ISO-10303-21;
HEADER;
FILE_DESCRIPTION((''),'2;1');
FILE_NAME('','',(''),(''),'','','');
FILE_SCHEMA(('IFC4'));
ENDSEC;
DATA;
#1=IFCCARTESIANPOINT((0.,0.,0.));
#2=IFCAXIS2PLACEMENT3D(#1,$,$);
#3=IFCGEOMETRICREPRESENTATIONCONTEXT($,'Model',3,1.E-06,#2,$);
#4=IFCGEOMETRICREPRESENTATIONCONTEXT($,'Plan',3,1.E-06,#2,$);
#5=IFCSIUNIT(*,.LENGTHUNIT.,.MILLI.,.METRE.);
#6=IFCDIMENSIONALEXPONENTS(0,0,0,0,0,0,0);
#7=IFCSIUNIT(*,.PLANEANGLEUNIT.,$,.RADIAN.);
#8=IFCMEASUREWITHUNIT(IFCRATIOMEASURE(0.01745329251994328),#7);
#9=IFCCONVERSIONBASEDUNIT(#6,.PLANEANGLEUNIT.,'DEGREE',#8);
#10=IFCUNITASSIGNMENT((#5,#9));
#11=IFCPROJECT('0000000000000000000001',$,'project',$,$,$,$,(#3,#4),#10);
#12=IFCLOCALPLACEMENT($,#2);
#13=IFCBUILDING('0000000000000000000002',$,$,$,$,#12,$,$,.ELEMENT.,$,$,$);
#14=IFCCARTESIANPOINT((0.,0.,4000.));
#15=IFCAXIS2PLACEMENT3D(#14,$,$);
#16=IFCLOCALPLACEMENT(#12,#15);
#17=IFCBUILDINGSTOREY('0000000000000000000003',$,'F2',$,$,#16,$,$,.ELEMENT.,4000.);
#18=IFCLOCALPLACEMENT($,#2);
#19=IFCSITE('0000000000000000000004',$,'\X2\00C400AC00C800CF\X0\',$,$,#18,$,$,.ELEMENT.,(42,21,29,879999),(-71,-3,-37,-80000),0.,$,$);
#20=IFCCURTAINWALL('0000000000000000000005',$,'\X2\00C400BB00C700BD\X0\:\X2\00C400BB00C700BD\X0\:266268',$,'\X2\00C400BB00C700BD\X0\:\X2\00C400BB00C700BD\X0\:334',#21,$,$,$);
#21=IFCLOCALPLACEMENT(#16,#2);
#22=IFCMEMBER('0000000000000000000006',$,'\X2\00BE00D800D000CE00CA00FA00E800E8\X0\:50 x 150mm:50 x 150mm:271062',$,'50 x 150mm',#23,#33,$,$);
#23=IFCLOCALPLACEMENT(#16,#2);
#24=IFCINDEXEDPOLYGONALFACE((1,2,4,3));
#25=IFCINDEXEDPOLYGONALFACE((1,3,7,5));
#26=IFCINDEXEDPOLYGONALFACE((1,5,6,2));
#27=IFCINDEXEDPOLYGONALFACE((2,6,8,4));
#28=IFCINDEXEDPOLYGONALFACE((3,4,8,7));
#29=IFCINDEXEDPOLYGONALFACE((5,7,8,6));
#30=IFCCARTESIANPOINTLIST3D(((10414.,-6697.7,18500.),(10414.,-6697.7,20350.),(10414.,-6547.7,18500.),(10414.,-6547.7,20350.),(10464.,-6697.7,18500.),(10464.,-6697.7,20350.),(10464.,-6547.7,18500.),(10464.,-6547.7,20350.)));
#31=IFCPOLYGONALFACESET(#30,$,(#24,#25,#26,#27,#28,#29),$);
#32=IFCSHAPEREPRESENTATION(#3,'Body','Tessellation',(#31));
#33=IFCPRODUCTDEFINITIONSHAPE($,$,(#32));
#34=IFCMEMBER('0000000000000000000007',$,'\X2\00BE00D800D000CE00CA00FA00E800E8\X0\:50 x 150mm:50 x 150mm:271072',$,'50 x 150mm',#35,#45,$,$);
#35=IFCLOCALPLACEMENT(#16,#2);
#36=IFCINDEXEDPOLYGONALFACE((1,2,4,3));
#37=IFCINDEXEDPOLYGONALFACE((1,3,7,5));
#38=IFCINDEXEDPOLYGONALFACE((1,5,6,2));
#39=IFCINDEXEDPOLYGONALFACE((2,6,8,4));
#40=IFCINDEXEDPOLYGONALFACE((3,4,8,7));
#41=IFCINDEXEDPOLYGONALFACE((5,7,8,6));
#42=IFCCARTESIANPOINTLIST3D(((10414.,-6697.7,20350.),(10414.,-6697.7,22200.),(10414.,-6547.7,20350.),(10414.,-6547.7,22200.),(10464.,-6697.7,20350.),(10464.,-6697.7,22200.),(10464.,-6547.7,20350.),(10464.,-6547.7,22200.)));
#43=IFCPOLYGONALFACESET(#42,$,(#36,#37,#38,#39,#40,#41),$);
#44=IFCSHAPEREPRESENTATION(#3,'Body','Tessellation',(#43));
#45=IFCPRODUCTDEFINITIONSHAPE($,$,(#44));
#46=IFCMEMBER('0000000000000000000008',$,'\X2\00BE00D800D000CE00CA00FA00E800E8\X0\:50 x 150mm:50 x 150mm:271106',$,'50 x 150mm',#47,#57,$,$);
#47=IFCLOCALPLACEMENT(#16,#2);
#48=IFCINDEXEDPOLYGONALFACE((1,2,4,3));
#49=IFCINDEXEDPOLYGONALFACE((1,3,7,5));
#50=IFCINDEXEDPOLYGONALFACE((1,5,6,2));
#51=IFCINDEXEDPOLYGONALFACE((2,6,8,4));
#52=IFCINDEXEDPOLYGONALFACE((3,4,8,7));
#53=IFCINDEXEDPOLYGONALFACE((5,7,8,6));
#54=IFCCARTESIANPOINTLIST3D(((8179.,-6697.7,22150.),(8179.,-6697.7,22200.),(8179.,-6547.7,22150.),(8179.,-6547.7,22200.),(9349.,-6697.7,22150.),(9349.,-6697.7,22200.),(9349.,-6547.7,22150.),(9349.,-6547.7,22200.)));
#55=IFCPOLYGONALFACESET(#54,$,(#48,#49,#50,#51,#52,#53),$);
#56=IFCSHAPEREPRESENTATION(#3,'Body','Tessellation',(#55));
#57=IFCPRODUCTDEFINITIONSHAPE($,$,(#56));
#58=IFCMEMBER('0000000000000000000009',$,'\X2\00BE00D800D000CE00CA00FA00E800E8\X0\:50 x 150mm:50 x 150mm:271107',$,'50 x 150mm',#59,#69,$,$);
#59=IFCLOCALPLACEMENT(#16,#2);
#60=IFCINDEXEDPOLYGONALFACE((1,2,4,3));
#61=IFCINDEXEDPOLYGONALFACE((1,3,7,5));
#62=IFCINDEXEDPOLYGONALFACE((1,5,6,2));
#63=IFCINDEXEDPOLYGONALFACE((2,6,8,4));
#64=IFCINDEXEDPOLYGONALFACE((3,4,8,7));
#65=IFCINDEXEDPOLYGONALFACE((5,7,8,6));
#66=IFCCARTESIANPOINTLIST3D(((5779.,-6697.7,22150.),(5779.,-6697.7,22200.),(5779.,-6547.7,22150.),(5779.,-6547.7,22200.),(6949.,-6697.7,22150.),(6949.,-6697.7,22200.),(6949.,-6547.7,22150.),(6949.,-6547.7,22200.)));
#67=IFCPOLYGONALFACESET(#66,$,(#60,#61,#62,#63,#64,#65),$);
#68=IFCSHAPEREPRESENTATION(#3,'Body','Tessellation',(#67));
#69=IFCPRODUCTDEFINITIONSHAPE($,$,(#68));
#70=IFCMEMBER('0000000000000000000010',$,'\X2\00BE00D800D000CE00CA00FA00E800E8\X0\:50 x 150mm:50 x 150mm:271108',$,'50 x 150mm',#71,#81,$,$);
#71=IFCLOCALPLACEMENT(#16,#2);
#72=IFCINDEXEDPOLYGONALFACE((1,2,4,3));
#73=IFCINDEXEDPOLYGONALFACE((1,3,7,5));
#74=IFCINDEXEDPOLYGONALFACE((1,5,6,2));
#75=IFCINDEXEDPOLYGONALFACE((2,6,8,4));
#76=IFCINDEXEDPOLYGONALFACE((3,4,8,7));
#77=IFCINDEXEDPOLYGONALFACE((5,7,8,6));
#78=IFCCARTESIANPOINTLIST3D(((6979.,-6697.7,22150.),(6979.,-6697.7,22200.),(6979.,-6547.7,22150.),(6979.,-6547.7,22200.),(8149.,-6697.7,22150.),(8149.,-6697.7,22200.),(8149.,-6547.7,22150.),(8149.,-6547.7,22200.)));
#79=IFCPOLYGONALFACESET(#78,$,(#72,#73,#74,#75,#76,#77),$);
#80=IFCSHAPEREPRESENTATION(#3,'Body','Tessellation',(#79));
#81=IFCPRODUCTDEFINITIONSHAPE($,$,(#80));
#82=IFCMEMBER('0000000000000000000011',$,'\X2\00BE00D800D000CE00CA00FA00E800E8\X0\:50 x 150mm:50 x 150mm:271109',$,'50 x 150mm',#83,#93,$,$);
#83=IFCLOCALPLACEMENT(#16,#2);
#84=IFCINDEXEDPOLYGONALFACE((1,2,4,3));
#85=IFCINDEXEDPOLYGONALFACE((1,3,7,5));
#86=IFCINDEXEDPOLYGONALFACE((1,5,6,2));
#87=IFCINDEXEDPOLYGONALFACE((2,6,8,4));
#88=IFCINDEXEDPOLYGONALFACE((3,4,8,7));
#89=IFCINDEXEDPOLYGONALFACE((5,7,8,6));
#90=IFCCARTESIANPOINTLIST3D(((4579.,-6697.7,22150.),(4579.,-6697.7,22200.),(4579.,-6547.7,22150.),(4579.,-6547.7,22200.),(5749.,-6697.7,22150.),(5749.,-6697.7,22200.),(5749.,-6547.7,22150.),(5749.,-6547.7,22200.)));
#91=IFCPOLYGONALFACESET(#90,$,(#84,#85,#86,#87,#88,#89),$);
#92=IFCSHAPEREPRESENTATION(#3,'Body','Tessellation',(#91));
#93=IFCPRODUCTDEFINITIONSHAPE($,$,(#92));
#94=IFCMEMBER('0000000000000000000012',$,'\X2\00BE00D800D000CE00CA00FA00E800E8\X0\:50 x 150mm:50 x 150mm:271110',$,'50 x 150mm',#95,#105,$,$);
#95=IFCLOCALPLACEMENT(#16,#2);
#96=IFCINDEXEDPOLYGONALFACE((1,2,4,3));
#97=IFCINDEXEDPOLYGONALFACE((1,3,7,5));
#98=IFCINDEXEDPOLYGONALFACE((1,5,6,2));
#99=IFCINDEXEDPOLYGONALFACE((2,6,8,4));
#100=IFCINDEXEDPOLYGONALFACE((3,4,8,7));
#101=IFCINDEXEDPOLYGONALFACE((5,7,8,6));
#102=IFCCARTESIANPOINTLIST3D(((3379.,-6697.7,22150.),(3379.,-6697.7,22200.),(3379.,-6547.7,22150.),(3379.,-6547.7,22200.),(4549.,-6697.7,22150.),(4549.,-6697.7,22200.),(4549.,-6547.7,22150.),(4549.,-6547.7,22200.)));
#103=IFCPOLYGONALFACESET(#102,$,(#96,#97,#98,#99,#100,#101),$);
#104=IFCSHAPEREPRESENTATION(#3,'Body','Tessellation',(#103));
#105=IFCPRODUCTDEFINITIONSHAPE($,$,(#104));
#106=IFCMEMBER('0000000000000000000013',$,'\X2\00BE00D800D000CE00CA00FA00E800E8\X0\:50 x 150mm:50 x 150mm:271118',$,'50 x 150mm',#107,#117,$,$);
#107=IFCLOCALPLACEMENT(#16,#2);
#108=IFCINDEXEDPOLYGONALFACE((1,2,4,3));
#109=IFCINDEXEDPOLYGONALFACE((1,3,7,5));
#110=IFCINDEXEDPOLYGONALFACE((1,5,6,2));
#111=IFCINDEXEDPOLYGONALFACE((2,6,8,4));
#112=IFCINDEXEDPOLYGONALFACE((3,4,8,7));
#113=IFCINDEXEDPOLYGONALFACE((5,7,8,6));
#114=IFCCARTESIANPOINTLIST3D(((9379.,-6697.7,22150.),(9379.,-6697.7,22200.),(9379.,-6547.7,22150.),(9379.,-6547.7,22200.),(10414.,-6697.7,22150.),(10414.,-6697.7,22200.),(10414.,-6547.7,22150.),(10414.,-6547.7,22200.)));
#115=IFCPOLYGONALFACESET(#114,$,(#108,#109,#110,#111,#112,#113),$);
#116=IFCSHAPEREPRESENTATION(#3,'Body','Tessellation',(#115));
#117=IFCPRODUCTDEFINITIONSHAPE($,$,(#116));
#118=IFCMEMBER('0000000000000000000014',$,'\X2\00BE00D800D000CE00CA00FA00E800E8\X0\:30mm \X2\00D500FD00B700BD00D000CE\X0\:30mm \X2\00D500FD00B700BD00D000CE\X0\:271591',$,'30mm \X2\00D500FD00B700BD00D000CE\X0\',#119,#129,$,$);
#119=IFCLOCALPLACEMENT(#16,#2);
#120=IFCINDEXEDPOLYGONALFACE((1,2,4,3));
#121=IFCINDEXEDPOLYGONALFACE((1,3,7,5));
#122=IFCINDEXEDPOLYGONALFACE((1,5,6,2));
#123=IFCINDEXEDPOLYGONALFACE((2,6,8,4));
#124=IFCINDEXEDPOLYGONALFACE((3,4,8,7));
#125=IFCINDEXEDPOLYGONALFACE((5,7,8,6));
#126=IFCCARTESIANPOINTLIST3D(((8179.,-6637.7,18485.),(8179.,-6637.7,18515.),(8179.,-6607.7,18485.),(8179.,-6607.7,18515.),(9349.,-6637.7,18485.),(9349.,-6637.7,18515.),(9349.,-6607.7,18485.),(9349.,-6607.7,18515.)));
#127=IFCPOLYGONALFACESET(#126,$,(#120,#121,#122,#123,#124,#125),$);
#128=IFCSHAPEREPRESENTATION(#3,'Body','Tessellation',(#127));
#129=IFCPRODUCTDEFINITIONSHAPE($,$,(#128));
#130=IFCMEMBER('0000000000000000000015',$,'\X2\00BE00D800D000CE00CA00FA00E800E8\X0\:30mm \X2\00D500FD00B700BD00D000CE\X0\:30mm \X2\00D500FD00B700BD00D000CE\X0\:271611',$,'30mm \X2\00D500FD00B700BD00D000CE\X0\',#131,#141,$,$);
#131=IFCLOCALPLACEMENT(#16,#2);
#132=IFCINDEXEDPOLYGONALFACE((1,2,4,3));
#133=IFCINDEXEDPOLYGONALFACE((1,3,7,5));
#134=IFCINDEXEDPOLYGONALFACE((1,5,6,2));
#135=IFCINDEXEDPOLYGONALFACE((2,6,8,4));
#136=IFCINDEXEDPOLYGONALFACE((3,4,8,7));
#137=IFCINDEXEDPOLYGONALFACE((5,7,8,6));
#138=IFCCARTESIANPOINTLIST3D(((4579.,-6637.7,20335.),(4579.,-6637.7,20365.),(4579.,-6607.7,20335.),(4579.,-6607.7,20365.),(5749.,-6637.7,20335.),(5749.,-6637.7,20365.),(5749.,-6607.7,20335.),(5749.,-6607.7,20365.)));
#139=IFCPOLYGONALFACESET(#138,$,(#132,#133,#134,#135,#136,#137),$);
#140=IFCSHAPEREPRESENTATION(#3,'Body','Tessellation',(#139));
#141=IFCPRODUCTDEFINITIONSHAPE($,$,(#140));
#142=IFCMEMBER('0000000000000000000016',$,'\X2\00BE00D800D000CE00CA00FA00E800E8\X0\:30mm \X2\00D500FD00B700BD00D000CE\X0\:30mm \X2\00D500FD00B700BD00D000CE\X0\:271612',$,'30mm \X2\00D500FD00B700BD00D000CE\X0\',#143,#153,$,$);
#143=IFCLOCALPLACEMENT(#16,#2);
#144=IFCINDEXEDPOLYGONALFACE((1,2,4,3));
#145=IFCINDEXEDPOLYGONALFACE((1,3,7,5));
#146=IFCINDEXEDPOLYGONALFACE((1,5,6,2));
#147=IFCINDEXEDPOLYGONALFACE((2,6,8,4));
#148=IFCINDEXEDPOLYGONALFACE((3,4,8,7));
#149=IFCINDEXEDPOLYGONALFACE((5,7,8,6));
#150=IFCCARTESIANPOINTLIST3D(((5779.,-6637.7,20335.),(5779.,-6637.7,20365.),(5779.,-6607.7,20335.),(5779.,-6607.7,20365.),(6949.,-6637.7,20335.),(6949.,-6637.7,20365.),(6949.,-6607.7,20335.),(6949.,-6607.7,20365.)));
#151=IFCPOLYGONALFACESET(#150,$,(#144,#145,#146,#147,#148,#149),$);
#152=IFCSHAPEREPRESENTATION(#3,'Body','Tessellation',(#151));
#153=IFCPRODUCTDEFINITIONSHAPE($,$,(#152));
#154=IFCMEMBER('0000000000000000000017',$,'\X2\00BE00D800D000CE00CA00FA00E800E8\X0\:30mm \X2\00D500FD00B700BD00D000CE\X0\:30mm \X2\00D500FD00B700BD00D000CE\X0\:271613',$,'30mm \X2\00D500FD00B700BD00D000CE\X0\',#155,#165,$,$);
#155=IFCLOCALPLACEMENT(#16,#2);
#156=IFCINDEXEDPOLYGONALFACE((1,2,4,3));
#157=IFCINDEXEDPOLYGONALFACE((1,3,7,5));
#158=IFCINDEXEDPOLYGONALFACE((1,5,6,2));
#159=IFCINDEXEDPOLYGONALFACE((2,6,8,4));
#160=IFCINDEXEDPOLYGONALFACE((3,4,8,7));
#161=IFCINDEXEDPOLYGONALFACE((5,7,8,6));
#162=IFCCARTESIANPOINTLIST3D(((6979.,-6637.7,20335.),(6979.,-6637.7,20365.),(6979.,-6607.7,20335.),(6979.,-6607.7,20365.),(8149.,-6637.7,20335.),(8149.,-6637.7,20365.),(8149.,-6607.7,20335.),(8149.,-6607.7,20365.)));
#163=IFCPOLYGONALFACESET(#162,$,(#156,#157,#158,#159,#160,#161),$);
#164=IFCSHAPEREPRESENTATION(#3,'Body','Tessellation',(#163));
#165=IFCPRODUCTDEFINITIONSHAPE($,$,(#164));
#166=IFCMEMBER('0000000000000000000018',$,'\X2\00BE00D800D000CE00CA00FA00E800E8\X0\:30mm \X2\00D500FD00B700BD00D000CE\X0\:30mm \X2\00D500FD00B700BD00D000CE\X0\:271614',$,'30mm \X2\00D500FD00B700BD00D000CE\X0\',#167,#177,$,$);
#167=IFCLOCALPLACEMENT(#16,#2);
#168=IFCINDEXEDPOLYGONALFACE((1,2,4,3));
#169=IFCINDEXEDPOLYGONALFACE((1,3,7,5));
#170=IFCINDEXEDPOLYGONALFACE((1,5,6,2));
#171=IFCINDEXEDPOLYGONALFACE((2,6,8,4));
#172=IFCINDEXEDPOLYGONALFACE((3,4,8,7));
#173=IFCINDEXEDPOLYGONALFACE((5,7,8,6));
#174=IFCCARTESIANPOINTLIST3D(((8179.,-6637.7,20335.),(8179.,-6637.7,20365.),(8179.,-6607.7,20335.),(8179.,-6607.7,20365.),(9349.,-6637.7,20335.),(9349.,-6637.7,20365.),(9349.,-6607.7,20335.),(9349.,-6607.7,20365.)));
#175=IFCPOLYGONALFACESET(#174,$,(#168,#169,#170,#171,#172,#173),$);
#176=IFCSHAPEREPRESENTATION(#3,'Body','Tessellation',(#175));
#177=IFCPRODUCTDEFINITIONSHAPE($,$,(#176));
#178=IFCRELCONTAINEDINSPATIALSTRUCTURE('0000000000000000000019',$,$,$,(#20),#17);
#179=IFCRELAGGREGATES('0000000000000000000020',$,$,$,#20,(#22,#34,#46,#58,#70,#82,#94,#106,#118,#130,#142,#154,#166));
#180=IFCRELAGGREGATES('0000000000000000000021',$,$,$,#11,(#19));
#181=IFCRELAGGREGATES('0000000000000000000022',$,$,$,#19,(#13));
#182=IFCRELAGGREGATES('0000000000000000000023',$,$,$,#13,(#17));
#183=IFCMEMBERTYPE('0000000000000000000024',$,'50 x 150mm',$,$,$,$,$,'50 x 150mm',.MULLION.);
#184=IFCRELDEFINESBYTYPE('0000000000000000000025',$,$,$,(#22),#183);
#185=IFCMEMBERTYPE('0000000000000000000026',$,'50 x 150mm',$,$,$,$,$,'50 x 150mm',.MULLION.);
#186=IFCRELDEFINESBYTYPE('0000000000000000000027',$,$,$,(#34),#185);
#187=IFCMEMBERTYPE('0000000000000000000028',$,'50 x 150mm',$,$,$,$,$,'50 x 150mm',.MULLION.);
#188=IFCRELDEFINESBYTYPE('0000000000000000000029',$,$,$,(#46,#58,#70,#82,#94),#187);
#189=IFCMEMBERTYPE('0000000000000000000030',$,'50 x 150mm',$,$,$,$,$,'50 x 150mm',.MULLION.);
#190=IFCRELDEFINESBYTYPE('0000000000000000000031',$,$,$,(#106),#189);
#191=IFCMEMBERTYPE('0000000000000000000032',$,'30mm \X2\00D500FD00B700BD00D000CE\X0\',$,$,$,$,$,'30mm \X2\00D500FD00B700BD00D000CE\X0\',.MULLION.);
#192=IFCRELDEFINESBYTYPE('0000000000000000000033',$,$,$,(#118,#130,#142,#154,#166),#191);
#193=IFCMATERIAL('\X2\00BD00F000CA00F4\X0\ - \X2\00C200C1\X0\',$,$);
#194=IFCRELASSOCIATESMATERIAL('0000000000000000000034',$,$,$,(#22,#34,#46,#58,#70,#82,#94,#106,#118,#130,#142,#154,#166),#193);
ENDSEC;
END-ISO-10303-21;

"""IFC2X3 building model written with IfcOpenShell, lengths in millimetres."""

from ifc_helpers import new_model, entity, si_unit, converted_unit, frame, origin, origin_2d_with_axis, place, context, project, spatial, rectangle, extrude, source, transform, mapped, material, type_object, type_shapes, element, aggregate, save


model = new_model("IFC2X3")

# Units and contexts
model_context = context("Model", 3, precision=1e-06, world=origin())
plan_context = context("Plan", 3, precision=1e-06, world=origin())
ifc_project = project(units=[si_unit("LENGTHUNIT", "METRE", prefix="MILLI"), converted_unit("PLANEANGLEUNIT", "DEGREE", entity("IfcRatioMeasure", 0.01745329251994328), si_unit("PLANEANGLEUNIT", "RADIAN"), dimensions=[0, 0, 0, 0, 0, 0, 0])], contexts=[model_context, plan_context])

# Site, building, storey
site_placement = place(None, origin())
site = spatial("IfcSite", under=ifc_project, at=site_placement, Name="Ä¬ÈÏ", CompositionType="ELEMENT", RefLatitude=(42, 21, 29, 879999), RefLongitude=(-71, -3, -37, -80000), RefElevation=0.0)
building_placement = place(None, origin())
building = spatial("IfcBuilding", under=site, at=building_placement, CompositionType="ELEMENT")
storey_placement = place(building_placement, frame((0.0, 0.0, 4000.0)))
storey = spatial("IfcBuildingStorey", under=building, at=storey_placement, Name="F2", CompositionType="ELEMENT", Elevation=4000.0)

# Curtain wall, members
curtain_wall_placement = place(storey_placement, origin())
curtain_wall = element("IfcCurtainWall", 1, at=curtain_wall_placement, inside=storey, Name="Ä»Ç½:Ä»Ç½:266268", ObjectType="Ä»Ç½:Ä»Ç½:334")
ifc_material_1 = material(Name="½ðÊô - ÂÁ")
member_type_1 = type_object("IfcMemberType", Name="50 x 150mm", ElementType="50 x 150mm", PredefinedType="MULLION")
shared_shape_1 = source(origin(), model_context, "Body", "SweptSolid", [
    extrude(rectangle(XDim=50.0, YDim=150.0, at=origin_2d_with_axis()), frame((-25.0, 0.0, -1850.0), z_axis=(0.0, 0.0, 1.0), x_axis=(-1.0, 0.0, 0.0)), (0.0, 0.0, 1.0), 1850.0),
])
type_shapes(member_type_1, [shared_shape_1])
placement_1 = place(building_placement, frame((0.0, 0.0, 22500.0)))
member_1_placement = place(placement_1, frame((10464.0, -6622.7, 0.0), z_axis=(0.0, 0.0, -1.0), x_axis=(1.0, 0.0, 0.0)))
member_1 = element("IfcMember", 2, at=member_1_placement, type_object=member_type_1, material=ifc_material_1, Name="¾ØÐÎÊúèè:50 x 150mm:50 x 150mm:271062", ObjectType="50 x 150mm", context=model_context, shape_type="MappedRepresentation", body=[
    mapped(shared_shape_1, transform((0.0, 0.0, 0.0), scale=1.0)),
])
member_type_2 = type_object("IfcMemberType", Name="50 x 150mm", ElementType="50 x 150mm", PredefinedType="MULLION")
shared_shape_2 = source(origin(), model_context, "Body", "SweptSolid", [
    extrude(rectangle(XDim=50.0, YDim=150.0, at=origin_2d_with_axis()), frame((-25.0, 0.0, -1850.0), z_axis=(0.0, 0.0, 1.0), x_axis=(-1.0, 0.0, 0.0)), (0.0, 0.0, 1.0), 1850.0),
])
type_shapes(member_type_2, [shared_shape_2])
member_2_placement = place(placement_1, frame((10464.0, -6622.7, 1850.0), z_axis=(0.0, 0.0, -1.0), x_axis=(1.0, 0.0, 0.0)))
member_2 = element("IfcMember", 3, at=member_2_placement, type_object=member_type_2, material=ifc_material_1, Name="¾ØÐÎÊúèè:50 x 150mm:50 x 150mm:271072", ObjectType="50 x 150mm", context=model_context, shape_type="MappedRepresentation", body=[
    mapped(shared_shape_2, transform((0.0, 0.0, 0.0), scale=1.0)),
])
member_type_3 = type_object("IfcMemberType", Name="50 x 150mm", ElementType="50 x 150mm", PredefinedType="MULLION")
shared_shape_3 = source(origin(), model_context, "Body", "SweptSolid", [
    extrude(rectangle(XDim=50.0, YDim=150.0, at=origin_2d_with_axis()), frame((-25.0, 0.0, -1170.0), z_axis=(0.0, 0.0, 1.0), x_axis=(-1.0, 0.0, 0.0)), (0.0, 0.0, 1.0), 1170.0),
])
type_shapes(member_type_3, [shared_shape_3])
placement_2 = place(building_placement, frame((0.0, 0.0, 26200.0)))
member_3_placement = place(placement_2, frame((9349.0, -6622.7, 0.0), z_axis=(1.0, 0.0, 0.0), x_axis=(0.0, 0.0, 1.0)))
member_3 = element("IfcMember", 4, at=member_3_placement, type_object=member_type_3, material=ifc_material_1, Name="¾ØÐÎÊúèè:50 x 150mm:50 x 150mm:271106", ObjectType="50 x 150mm", context=model_context, shape_type="MappedRepresentation", body=[
    mapped(shared_shape_3, transform((0.0, 0.0, 0.0), scale=1.0)),
])
member_4_placement = place(placement_2, frame((6949.0, -6622.7, 0.0), z_axis=(1.0, 0.0, 0.0), x_axis=(0.0, 0.0, 1.0)))
member_4 = element("IfcMember", 5, at=member_4_placement, type_object=member_type_3, material=ifc_material_1, Name="¾ØÐÎÊúèè:50 x 150mm:50 x 150mm:271107", ObjectType="50 x 150mm", context=model_context, shape_type="MappedRepresentation", body=[
    mapped(shared_shape_3, transform((0.0, 0.0, 0.0), scale=1.0)),
])
member_5_placement = place(placement_2, frame((8149.0, -6622.7, 0.0), z_axis=(1.0, 0.0, 0.0), x_axis=(0.0, 0.0, 1.0)))
member_5 = element("IfcMember", 6, at=member_5_placement, type_object=member_type_3, material=ifc_material_1, Name="¾ØÐÎÊúèè:50 x 150mm:50 x 150mm:271108", ObjectType="50 x 150mm", context=model_context, shape_type="MappedRepresentation", body=[
    mapped(shared_shape_3, transform((0.0, 0.0, 0.0), scale=1.0)),
])
member_6_placement = place(placement_2, frame((5749.0, -6622.7, 0.0), z_axis=(1.0, 0.0, 0.0), x_axis=(0.0, 0.0, 1.0)))
member_6 = element("IfcMember", 7, at=member_6_placement, type_object=member_type_3, material=ifc_material_1, Name="¾ØÐÎÊúèè:50 x 150mm:50 x 150mm:271109", ObjectType="50 x 150mm", context=model_context, shape_type="MappedRepresentation", body=[
    mapped(shared_shape_3, transform((0.0, 0.0, 0.0), scale=1.0)),
])
member_7_placement = place(placement_2, frame((4549.0, -6622.7, 0.0), z_axis=(1.0, 0.0, 0.0), x_axis=(0.0, 0.0, 1.0)))
member_7 = element("IfcMember", 8, at=member_7_placement, type_object=member_type_3, material=ifc_material_1, Name="¾ØÐÎÊúèè:50 x 150mm:50 x 150mm:271110", ObjectType="50 x 150mm", context=model_context, shape_type="MappedRepresentation", body=[
    mapped(shared_shape_3, transform((0.0, 0.0, 0.0), scale=1.0)),
])
member_type_4 = type_object("IfcMemberType", Name="50 x 150mm", ElementType="50 x 150mm", PredefinedType="MULLION")
shared_shape_4 = source(origin(), model_context, "Body", "SweptSolid", [
    extrude(rectangle(XDim=50.0, YDim=150.0, at=origin_2d_with_axis()), frame((-25.0, 0.0, -1035.0), z_axis=(0.0, 0.0, 1.0), x_axis=(-1.0, 0.0, 0.0)), (0.0, 0.0, 1.0), 1035.0),
])
type_shapes(member_type_4, [shared_shape_4])
member_8_placement = place(placement_2, frame((10414.0, -6622.7, 0.0), z_axis=(1.0, 0.0, 0.0), x_axis=(0.0, 0.0, 1.0)))
member_8 = element("IfcMember", 9, at=member_8_placement, type_object=member_type_4, material=ifc_material_1, Name="¾ØÐÎÊúèè:50 x 150mm:50 x 150mm:271118", ObjectType="50 x 150mm", context=model_context, shape_type="MappedRepresentation", body=[
    mapped(shared_shape_4, transform((0.0, 0.0, 0.0), scale=1.0)),
])
member_type_5 = type_object("IfcMemberType", Name="30mm Õý·½ÐÎ", ElementType="30mm Õý·½ÐÎ", PredefinedType="MULLION")
shared_shape_5 = source(origin(), model_context, "Body", "SweptSolid", [
    extrude(rectangle(XDim=30.0, YDim=30.0, at=origin_2d_with_axis()), frame((0.0, 0.0, -1170.0), z_axis=(0.0, 0.0, 1.0), x_axis=(-1.0, 0.0, 0.0)), (0.0, 0.0, 1.0), 1170.0),
])
type_shapes(member_type_5, [shared_shape_5])
member_9_placement = place(placement_1, frame((9349.0, -6622.7, 0.0), z_axis=(1.0, 0.0, 0.0), x_axis=(0.0, 0.0, 1.0)))
member_9 = element("IfcMember", 10, at=member_9_placement, type_object=member_type_5, material=ifc_material_1, Name="¾ØÐÎÊúèè:30mm Õý·½ÐÎ:30mm Õý·½ÐÎ:271591", ObjectType="30mm Õý·½ÐÎ", context=model_context, shape_type="MappedRepresentation", body=[
    mapped(shared_shape_5, transform((0.0, 0.0, 0.0), scale=1.0)),
])
member_10_placement = place(placement_1, frame((5749.0, -6622.7, 1850.0), z_axis=(1.0, 0.0, 0.0), x_axis=(0.0, 0.0, 1.0)))
member_10 = element("IfcMember", 11, at=member_10_placement, type_object=member_type_5, material=ifc_material_1, Name="¾ØÐÎÊúèè:30mm Õý·½ÐÎ:30mm Õý·½ÐÎ:271611", ObjectType="30mm Õý·½ÐÎ", context=model_context, shape_type="MappedRepresentation", body=[
    mapped(shared_shape_5, transform((0.0, 0.0, 0.0), scale=1.0)),
])
member_11_placement = place(placement_1, frame((6949.0, -6622.7, 1850.0), z_axis=(1.0, 0.0, 0.0), x_axis=(0.0, 0.0, 1.0)))
member_11 = element("IfcMember", 12, at=member_11_placement, type_object=member_type_5, material=ifc_material_1, Name="¾ØÐÎÊúèè:30mm Õý·½ÐÎ:30mm Õý·½ÐÎ:271612", ObjectType="30mm Õý·½ÐÎ", context=model_context, shape_type="MappedRepresentation", body=[
    mapped(shared_shape_5, transform((0.0, 0.0, 0.0), scale=1.0)),
])
member_12_placement = place(placement_1, frame((8149.0, -6622.7, 1850.0), z_axis=(1.0, 0.0, 0.0), x_axis=(0.0, 0.0, 1.0)))
member_12 = element("IfcMember", 13, at=member_12_placement, type_object=member_type_5, material=ifc_material_1, Name="¾ØÐÎÊúèè:30mm Õý·½ÐÎ:30mm Õý·½ÐÎ:271613", ObjectType="30mm Õý·½ÐÎ", context=model_context, shape_type="MappedRepresentation", body=[
    mapped(shared_shape_5, transform((0.0, 0.0, 0.0), scale=1.0)),
])
member_13_placement = place(placement_1, frame((9349.0, -6622.7, 1850.0), z_axis=(1.0, 0.0, 0.0), x_axis=(0.0, 0.0, 1.0)))
member_13 = element("IfcMember", 14, at=member_13_placement, type_object=member_type_5, material=ifc_material_1, Name="¾ØÐÎÊúèè:30mm Õý·½ÐÎ:30mm Õý·½ÐÎ:271614", ObjectType="30mm Õý·½ÐÎ", context=model_context, shape_type="MappedRepresentation", body=[
    mapped(shared_shape_5, transform((0.0, 0.0, 0.0), scale=1.0)),
])
aggregate(curtain_wall, [member_1, member_2, member_3, member_4, member_5, member_6, member_7, member_8, member_9, member_10, member_11, member_12, member_13])

save(model, "model.ifc")
